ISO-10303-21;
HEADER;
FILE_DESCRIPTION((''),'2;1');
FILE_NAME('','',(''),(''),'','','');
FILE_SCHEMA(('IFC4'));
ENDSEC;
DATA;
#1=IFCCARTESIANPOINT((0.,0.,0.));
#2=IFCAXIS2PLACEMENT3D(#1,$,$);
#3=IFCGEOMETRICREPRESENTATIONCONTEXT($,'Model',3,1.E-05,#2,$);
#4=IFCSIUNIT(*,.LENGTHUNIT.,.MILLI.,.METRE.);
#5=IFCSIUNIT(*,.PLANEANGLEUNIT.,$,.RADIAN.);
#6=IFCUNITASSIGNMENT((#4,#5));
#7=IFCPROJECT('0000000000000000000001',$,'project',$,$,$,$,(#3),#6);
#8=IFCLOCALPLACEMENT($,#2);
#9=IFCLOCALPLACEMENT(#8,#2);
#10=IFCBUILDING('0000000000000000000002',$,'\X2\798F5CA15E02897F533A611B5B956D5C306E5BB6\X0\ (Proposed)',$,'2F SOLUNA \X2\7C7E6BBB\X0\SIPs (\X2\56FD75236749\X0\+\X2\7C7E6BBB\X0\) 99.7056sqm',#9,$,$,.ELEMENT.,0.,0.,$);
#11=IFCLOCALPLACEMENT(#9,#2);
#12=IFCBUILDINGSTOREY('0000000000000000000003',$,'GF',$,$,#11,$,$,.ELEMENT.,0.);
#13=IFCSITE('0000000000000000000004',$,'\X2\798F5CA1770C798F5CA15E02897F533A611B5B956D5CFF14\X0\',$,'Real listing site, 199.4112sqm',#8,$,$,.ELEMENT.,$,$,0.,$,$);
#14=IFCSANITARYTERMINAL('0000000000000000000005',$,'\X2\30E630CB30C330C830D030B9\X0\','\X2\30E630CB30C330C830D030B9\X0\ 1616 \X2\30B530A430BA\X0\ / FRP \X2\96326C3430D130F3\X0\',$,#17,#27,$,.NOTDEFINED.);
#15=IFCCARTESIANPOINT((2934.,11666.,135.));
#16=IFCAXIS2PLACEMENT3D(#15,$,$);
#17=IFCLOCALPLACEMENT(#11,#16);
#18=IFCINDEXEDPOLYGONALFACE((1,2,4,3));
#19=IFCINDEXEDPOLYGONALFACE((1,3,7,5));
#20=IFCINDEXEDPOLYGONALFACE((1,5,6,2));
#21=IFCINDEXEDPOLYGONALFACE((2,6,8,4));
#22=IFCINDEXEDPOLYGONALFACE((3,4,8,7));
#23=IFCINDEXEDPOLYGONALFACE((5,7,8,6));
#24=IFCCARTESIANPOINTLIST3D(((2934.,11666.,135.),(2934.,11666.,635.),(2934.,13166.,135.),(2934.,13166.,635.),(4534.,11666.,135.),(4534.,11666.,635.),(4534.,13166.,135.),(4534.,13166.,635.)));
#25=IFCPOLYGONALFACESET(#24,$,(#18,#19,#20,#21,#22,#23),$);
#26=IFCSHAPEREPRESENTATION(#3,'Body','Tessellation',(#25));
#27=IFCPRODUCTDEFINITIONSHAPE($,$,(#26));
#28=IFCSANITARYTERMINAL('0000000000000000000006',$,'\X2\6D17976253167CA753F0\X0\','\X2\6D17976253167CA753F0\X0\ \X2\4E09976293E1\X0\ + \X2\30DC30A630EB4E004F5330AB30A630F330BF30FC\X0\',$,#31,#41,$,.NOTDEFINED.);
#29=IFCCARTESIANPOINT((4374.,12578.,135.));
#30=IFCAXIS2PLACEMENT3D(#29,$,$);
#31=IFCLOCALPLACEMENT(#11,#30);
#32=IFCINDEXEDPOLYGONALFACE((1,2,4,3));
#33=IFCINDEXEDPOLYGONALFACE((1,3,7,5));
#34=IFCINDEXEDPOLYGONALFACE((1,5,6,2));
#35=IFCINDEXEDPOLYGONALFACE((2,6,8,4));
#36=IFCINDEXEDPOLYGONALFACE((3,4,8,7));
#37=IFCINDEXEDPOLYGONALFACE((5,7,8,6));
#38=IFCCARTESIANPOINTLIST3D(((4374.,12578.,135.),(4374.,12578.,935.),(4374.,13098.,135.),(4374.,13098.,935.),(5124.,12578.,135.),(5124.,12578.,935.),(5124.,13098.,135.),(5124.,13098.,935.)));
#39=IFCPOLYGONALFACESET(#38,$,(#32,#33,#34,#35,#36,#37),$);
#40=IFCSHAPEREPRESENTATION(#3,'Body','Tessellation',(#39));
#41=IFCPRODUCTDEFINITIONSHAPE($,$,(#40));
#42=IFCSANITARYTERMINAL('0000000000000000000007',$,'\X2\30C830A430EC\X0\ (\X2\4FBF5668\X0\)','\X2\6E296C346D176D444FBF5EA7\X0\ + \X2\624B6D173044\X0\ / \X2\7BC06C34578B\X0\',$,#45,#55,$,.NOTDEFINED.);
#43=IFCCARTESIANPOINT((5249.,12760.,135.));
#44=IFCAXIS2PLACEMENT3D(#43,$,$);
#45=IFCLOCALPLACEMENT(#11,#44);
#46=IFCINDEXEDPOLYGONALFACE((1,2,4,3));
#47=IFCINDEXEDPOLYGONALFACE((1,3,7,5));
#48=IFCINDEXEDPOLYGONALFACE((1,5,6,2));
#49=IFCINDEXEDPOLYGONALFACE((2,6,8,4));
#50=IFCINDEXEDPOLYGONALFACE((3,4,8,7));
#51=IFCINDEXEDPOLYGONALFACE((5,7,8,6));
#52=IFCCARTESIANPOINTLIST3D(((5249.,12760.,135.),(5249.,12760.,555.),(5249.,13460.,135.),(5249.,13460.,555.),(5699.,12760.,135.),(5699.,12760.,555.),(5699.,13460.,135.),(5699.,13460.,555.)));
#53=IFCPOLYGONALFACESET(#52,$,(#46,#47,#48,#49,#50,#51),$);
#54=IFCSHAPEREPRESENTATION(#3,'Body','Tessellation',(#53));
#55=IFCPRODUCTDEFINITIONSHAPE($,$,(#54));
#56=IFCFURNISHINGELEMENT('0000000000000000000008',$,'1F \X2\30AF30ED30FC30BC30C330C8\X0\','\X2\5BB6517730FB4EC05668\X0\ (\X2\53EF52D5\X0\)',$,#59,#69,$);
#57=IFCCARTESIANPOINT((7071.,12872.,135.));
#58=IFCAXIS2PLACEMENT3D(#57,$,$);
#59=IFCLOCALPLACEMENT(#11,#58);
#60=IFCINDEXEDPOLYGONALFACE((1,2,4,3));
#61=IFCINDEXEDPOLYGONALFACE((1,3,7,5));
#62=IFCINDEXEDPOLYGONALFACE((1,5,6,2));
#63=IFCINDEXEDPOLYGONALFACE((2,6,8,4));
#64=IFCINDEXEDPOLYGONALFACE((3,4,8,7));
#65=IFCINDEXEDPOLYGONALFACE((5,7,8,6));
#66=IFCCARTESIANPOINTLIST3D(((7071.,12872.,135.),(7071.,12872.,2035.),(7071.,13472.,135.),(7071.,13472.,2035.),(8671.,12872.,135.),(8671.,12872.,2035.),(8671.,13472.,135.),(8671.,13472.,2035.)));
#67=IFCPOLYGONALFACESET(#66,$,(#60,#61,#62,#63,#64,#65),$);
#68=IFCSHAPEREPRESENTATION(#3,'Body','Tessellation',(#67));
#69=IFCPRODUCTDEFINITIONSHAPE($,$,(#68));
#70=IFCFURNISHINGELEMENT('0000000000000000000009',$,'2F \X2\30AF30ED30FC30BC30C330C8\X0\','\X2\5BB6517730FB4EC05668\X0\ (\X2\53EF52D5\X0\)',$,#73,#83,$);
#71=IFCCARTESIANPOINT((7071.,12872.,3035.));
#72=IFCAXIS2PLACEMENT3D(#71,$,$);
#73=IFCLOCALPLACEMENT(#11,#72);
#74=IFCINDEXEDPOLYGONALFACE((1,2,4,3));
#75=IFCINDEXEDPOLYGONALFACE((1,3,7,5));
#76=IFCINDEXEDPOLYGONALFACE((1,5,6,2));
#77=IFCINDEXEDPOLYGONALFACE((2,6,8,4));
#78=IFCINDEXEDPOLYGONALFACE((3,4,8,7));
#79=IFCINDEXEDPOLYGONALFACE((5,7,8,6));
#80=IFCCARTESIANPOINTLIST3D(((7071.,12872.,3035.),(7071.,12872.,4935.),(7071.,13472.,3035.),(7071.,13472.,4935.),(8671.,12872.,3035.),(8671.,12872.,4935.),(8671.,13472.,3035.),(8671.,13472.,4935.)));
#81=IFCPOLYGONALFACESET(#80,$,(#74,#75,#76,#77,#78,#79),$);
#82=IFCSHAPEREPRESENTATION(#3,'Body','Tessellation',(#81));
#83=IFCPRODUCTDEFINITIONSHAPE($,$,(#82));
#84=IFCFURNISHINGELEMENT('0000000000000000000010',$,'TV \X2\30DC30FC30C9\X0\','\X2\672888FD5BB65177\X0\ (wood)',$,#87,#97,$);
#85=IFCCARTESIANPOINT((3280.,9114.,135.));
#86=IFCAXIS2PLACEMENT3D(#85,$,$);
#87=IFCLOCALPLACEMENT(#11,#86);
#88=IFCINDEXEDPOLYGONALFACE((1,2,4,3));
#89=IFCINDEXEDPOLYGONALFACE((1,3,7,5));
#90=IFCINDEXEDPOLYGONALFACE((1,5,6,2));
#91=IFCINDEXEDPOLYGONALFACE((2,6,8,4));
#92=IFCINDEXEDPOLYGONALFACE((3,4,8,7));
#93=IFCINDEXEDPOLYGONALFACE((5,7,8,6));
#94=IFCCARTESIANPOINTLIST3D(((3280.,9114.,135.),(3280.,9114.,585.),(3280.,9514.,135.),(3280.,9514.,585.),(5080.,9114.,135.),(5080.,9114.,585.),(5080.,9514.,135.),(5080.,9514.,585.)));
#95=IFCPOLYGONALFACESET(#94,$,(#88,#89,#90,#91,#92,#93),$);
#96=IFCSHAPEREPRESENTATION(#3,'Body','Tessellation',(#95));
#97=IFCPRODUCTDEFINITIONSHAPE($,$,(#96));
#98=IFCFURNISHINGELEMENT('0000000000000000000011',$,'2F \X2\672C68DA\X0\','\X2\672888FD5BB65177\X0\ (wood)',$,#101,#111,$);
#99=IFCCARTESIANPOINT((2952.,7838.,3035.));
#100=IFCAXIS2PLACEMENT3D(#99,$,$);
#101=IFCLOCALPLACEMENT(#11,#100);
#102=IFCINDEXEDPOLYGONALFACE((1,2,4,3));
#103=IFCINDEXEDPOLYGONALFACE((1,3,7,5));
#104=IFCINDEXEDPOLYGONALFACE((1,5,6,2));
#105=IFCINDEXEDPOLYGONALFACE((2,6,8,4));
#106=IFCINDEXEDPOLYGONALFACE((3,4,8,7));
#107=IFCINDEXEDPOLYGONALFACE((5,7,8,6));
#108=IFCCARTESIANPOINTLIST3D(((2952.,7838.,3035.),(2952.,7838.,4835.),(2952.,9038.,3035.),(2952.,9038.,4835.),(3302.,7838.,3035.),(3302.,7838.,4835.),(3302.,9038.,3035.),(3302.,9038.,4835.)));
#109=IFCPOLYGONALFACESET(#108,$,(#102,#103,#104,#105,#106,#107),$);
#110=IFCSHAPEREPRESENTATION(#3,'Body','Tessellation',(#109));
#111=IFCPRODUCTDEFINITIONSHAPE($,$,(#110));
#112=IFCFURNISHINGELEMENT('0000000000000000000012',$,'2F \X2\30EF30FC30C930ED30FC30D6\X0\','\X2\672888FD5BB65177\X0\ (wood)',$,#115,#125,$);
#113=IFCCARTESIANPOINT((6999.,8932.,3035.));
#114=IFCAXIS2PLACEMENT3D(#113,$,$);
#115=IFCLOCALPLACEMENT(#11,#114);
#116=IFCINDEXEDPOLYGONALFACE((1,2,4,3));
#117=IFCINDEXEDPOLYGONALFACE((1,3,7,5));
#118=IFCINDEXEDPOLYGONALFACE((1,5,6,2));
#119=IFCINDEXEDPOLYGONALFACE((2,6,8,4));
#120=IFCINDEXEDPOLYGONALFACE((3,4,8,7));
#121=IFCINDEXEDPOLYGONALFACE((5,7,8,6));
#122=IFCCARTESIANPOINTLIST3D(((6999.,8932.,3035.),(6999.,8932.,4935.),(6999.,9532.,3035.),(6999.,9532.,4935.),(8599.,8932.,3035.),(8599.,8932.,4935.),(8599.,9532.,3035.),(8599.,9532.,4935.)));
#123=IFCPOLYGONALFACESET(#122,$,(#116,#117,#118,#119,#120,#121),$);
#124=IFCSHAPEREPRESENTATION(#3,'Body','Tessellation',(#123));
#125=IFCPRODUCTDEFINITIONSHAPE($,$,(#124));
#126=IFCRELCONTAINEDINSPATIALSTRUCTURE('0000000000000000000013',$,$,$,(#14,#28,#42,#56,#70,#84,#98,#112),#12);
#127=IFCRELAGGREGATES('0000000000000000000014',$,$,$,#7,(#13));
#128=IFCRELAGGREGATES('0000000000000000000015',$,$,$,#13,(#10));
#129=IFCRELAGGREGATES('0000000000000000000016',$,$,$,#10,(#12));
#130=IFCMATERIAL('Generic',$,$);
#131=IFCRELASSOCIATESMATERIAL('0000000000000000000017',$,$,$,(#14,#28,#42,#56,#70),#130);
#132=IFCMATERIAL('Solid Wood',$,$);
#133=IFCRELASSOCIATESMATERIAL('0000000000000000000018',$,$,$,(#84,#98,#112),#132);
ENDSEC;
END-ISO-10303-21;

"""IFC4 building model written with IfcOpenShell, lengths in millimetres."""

from ifc_helpers import new_model, si_unit, frame, frame_2d, origin, place, context, project, spatial, rectangle, extrude, material, element, save


model = new_model("IFC4")

# Units and contexts
model_context = context("Model", 3, precision=1e-05, world=origin())
ifc_project = project(units=[si_unit("LENGTHUNIT", "METRE", prefix="MILLI"), si_unit("PLANEANGLEUNIT", "RADIAN")], contexts=[model_context])

# Site, building, storey
site_placement = place(None, origin())
site = spatial("IfcSite", under=ifc_project, at=site_placement, Name="福岡県福岡市西区愛宕浜４", ObjectType="Real listing site, 199.4112sqm", CompositionType="ELEMENT", RefElevation=0.0)
building_placement = place(site_placement, origin())
building = spatial("IfcBuilding", under=site, at=building_placement, Name="福岡市西区愛宕浜の家 (Proposed)", ObjectType="2F SOLUNA 籾殻SIPs (国産杉+籾殻) 99.7056sqm", CompositionType="ELEMENT", ElevationOfRefHeight=0.0, ElevationOfTerrain=0.0)
storey_placement = place(building_placement, origin())
storey = spatial("IfcBuildingStorey", under=building, at=storey_placement, Name="GF", CompositionType="ELEMENT", Elevation=0.0)

# Shared definitions
ifc_material_1 = material(Name="Solid Wood")

# Sanitary terminals
ifc_material_2 = material(Name="Generic")
sanitary_terminal_1_placement = place(storey_placement, frame((2934.0, 11666.0, 135.0)))
element("IfcSanitaryTerminal", 1, at=sanitary_terminal_1_placement, inside=storey, material=ifc_material_2, Name="ユニットバス", Description="ユニットバス 1616 サイズ / FRP 防水パン", PredefinedType="NOTDEFINED", context=model_context, shape_type="SweptSolid", body=[
    extrude(rectangle(XDim=1600.0, YDim=1500.0, at=frame_2d((800.0, 750.0))), frame((2934.0, 11666.0, 135.0)), (0.0, 0.0, 1.0), 500.0),
])
sanitary_terminal_2_placement = place(storey_placement, frame((4374.0, 12578.0, 135.0)))
element("IfcSanitaryTerminal", 2, at=sanitary_terminal_2_placement, inside=storey, material=ifc_material_2, Name="洗面化粧台", Description="洗面化粧台 三面鏡 + ボウル一体カウンター", PredefinedType="NOTDEFINED", context=model_context, shape_type="SweptSolid", body=[
    extrude(rectangle(XDim=750.0, YDim=520.0, at=frame_2d((375.0, 260.0))), frame((4374.0, 12578.0, 135.0)), (0.0, 0.0, 1.0), 800.0),
])
sanitary_terminal_3_placement = place(storey_placement, frame((5249.0, 12760.0, 135.0)))
element("IfcSanitaryTerminal", 3, at=sanitary_terminal_3_placement, inside=storey, material=ifc_material_2, Name="トイレ (便器)", Description="温水洗浄便座 + 手洗い / 節水型", PredefinedType="NOTDEFINED", context=model_context, shape_type="SweptSolid", body=[
    extrude(rectangle(XDim=450.0, YDim=700.0, at=frame_2d((225.0, 350.0))), frame((5249.0, 12760.0, 135.0)), (0.0, 0.0, 1.0), 420.0),
])

# Furnishing elements
furnishing_1_placement = place(storey_placement, frame((7071.0, 12872.0, 135.0)))
element("IfcFurnishingElement", 4, at=furnishing_1_placement, inside=storey, material=ifc_material_2, Name="1F クローゼット", Description="家具・什器 (可動)", context=model_context, shape_type="SweptSolid", body=[
    extrude(rectangle(XDim=1600.0, YDim=600.0, at=frame_2d((800.0, 300.0))), frame((7071.0, 12872.0, 135.0)), (0.0, 0.0, 1.0), 1900.0),
])
furnishing_2_placement = place(storey_placement, frame((7071.0, 12872.0, 3035.0)))
element("IfcFurnishingElement", 5, at=furnishing_2_placement, inside=storey, material=ifc_material_2, Name="2F クローゼット", Description="家具・什器 (可動)", context=model_context, shape_type="SweptSolid", body=[
    extrude(rectangle(XDim=1600.0, YDim=600.0, at=frame_2d((800.0, 300.0))), frame((7071.0, 12872.0, 3035.0)), (0.0, 0.0, 1.0), 1900.0),
])
furnishing_3_placement = place(storey_placement, frame((3280.0, 9114.0, 135.0)))
element("IfcFurnishingElement", 6, at=furnishing_3_placement, inside=storey, material=ifc_material_1, Name="TV ボード", Description="木製家具 (wood)", context=model_context, shape_type="SweptSolid", body=[
    extrude(rectangle(XDim=1800.0, YDim=400.0, at=frame_2d((900.0, 200.0))), frame((3280.0, 9114.0, 135.0)), (0.0, 0.0, 1.0), 450.0),
])
furnishing_4_placement = place(storey_placement, frame((2952.0, 7838.0, 3035.0)))
element("IfcFurnishingElement", 7, at=furnishing_4_placement, inside=storey, material=ifc_material_1, Name="2F 本棚", Description="木製家具 (wood)", context=model_context, shape_type="SweptSolid", body=[
    extrude(rectangle(XDim=350.0, YDim=1200.0, at=frame_2d((175.0, 600.0))), frame((2952.0, 7838.0, 3035.0)), (0.0, 0.0, 1.0), 1800.0),
])
furnishing_5_placement = place(storey_placement, frame((6999.0, 8932.0, 3035.0)))
element("IfcFurnishingElement", 8, at=furnishing_5_placement, inside=storey, material=ifc_material_1, Name="2F ワードローブ", Description="木製家具 (wood)", context=model_context, shape_type="SweptSolid", body=[
    extrude(rectangle(XDim=1600.0, YDim=600.0, at=frame_2d((800.0, 300.0))), frame((6999.0, 8932.0, 3035.0)), (0.0, 0.0, 1.0), 1900.0),
])

save(model, "model.ifc")
